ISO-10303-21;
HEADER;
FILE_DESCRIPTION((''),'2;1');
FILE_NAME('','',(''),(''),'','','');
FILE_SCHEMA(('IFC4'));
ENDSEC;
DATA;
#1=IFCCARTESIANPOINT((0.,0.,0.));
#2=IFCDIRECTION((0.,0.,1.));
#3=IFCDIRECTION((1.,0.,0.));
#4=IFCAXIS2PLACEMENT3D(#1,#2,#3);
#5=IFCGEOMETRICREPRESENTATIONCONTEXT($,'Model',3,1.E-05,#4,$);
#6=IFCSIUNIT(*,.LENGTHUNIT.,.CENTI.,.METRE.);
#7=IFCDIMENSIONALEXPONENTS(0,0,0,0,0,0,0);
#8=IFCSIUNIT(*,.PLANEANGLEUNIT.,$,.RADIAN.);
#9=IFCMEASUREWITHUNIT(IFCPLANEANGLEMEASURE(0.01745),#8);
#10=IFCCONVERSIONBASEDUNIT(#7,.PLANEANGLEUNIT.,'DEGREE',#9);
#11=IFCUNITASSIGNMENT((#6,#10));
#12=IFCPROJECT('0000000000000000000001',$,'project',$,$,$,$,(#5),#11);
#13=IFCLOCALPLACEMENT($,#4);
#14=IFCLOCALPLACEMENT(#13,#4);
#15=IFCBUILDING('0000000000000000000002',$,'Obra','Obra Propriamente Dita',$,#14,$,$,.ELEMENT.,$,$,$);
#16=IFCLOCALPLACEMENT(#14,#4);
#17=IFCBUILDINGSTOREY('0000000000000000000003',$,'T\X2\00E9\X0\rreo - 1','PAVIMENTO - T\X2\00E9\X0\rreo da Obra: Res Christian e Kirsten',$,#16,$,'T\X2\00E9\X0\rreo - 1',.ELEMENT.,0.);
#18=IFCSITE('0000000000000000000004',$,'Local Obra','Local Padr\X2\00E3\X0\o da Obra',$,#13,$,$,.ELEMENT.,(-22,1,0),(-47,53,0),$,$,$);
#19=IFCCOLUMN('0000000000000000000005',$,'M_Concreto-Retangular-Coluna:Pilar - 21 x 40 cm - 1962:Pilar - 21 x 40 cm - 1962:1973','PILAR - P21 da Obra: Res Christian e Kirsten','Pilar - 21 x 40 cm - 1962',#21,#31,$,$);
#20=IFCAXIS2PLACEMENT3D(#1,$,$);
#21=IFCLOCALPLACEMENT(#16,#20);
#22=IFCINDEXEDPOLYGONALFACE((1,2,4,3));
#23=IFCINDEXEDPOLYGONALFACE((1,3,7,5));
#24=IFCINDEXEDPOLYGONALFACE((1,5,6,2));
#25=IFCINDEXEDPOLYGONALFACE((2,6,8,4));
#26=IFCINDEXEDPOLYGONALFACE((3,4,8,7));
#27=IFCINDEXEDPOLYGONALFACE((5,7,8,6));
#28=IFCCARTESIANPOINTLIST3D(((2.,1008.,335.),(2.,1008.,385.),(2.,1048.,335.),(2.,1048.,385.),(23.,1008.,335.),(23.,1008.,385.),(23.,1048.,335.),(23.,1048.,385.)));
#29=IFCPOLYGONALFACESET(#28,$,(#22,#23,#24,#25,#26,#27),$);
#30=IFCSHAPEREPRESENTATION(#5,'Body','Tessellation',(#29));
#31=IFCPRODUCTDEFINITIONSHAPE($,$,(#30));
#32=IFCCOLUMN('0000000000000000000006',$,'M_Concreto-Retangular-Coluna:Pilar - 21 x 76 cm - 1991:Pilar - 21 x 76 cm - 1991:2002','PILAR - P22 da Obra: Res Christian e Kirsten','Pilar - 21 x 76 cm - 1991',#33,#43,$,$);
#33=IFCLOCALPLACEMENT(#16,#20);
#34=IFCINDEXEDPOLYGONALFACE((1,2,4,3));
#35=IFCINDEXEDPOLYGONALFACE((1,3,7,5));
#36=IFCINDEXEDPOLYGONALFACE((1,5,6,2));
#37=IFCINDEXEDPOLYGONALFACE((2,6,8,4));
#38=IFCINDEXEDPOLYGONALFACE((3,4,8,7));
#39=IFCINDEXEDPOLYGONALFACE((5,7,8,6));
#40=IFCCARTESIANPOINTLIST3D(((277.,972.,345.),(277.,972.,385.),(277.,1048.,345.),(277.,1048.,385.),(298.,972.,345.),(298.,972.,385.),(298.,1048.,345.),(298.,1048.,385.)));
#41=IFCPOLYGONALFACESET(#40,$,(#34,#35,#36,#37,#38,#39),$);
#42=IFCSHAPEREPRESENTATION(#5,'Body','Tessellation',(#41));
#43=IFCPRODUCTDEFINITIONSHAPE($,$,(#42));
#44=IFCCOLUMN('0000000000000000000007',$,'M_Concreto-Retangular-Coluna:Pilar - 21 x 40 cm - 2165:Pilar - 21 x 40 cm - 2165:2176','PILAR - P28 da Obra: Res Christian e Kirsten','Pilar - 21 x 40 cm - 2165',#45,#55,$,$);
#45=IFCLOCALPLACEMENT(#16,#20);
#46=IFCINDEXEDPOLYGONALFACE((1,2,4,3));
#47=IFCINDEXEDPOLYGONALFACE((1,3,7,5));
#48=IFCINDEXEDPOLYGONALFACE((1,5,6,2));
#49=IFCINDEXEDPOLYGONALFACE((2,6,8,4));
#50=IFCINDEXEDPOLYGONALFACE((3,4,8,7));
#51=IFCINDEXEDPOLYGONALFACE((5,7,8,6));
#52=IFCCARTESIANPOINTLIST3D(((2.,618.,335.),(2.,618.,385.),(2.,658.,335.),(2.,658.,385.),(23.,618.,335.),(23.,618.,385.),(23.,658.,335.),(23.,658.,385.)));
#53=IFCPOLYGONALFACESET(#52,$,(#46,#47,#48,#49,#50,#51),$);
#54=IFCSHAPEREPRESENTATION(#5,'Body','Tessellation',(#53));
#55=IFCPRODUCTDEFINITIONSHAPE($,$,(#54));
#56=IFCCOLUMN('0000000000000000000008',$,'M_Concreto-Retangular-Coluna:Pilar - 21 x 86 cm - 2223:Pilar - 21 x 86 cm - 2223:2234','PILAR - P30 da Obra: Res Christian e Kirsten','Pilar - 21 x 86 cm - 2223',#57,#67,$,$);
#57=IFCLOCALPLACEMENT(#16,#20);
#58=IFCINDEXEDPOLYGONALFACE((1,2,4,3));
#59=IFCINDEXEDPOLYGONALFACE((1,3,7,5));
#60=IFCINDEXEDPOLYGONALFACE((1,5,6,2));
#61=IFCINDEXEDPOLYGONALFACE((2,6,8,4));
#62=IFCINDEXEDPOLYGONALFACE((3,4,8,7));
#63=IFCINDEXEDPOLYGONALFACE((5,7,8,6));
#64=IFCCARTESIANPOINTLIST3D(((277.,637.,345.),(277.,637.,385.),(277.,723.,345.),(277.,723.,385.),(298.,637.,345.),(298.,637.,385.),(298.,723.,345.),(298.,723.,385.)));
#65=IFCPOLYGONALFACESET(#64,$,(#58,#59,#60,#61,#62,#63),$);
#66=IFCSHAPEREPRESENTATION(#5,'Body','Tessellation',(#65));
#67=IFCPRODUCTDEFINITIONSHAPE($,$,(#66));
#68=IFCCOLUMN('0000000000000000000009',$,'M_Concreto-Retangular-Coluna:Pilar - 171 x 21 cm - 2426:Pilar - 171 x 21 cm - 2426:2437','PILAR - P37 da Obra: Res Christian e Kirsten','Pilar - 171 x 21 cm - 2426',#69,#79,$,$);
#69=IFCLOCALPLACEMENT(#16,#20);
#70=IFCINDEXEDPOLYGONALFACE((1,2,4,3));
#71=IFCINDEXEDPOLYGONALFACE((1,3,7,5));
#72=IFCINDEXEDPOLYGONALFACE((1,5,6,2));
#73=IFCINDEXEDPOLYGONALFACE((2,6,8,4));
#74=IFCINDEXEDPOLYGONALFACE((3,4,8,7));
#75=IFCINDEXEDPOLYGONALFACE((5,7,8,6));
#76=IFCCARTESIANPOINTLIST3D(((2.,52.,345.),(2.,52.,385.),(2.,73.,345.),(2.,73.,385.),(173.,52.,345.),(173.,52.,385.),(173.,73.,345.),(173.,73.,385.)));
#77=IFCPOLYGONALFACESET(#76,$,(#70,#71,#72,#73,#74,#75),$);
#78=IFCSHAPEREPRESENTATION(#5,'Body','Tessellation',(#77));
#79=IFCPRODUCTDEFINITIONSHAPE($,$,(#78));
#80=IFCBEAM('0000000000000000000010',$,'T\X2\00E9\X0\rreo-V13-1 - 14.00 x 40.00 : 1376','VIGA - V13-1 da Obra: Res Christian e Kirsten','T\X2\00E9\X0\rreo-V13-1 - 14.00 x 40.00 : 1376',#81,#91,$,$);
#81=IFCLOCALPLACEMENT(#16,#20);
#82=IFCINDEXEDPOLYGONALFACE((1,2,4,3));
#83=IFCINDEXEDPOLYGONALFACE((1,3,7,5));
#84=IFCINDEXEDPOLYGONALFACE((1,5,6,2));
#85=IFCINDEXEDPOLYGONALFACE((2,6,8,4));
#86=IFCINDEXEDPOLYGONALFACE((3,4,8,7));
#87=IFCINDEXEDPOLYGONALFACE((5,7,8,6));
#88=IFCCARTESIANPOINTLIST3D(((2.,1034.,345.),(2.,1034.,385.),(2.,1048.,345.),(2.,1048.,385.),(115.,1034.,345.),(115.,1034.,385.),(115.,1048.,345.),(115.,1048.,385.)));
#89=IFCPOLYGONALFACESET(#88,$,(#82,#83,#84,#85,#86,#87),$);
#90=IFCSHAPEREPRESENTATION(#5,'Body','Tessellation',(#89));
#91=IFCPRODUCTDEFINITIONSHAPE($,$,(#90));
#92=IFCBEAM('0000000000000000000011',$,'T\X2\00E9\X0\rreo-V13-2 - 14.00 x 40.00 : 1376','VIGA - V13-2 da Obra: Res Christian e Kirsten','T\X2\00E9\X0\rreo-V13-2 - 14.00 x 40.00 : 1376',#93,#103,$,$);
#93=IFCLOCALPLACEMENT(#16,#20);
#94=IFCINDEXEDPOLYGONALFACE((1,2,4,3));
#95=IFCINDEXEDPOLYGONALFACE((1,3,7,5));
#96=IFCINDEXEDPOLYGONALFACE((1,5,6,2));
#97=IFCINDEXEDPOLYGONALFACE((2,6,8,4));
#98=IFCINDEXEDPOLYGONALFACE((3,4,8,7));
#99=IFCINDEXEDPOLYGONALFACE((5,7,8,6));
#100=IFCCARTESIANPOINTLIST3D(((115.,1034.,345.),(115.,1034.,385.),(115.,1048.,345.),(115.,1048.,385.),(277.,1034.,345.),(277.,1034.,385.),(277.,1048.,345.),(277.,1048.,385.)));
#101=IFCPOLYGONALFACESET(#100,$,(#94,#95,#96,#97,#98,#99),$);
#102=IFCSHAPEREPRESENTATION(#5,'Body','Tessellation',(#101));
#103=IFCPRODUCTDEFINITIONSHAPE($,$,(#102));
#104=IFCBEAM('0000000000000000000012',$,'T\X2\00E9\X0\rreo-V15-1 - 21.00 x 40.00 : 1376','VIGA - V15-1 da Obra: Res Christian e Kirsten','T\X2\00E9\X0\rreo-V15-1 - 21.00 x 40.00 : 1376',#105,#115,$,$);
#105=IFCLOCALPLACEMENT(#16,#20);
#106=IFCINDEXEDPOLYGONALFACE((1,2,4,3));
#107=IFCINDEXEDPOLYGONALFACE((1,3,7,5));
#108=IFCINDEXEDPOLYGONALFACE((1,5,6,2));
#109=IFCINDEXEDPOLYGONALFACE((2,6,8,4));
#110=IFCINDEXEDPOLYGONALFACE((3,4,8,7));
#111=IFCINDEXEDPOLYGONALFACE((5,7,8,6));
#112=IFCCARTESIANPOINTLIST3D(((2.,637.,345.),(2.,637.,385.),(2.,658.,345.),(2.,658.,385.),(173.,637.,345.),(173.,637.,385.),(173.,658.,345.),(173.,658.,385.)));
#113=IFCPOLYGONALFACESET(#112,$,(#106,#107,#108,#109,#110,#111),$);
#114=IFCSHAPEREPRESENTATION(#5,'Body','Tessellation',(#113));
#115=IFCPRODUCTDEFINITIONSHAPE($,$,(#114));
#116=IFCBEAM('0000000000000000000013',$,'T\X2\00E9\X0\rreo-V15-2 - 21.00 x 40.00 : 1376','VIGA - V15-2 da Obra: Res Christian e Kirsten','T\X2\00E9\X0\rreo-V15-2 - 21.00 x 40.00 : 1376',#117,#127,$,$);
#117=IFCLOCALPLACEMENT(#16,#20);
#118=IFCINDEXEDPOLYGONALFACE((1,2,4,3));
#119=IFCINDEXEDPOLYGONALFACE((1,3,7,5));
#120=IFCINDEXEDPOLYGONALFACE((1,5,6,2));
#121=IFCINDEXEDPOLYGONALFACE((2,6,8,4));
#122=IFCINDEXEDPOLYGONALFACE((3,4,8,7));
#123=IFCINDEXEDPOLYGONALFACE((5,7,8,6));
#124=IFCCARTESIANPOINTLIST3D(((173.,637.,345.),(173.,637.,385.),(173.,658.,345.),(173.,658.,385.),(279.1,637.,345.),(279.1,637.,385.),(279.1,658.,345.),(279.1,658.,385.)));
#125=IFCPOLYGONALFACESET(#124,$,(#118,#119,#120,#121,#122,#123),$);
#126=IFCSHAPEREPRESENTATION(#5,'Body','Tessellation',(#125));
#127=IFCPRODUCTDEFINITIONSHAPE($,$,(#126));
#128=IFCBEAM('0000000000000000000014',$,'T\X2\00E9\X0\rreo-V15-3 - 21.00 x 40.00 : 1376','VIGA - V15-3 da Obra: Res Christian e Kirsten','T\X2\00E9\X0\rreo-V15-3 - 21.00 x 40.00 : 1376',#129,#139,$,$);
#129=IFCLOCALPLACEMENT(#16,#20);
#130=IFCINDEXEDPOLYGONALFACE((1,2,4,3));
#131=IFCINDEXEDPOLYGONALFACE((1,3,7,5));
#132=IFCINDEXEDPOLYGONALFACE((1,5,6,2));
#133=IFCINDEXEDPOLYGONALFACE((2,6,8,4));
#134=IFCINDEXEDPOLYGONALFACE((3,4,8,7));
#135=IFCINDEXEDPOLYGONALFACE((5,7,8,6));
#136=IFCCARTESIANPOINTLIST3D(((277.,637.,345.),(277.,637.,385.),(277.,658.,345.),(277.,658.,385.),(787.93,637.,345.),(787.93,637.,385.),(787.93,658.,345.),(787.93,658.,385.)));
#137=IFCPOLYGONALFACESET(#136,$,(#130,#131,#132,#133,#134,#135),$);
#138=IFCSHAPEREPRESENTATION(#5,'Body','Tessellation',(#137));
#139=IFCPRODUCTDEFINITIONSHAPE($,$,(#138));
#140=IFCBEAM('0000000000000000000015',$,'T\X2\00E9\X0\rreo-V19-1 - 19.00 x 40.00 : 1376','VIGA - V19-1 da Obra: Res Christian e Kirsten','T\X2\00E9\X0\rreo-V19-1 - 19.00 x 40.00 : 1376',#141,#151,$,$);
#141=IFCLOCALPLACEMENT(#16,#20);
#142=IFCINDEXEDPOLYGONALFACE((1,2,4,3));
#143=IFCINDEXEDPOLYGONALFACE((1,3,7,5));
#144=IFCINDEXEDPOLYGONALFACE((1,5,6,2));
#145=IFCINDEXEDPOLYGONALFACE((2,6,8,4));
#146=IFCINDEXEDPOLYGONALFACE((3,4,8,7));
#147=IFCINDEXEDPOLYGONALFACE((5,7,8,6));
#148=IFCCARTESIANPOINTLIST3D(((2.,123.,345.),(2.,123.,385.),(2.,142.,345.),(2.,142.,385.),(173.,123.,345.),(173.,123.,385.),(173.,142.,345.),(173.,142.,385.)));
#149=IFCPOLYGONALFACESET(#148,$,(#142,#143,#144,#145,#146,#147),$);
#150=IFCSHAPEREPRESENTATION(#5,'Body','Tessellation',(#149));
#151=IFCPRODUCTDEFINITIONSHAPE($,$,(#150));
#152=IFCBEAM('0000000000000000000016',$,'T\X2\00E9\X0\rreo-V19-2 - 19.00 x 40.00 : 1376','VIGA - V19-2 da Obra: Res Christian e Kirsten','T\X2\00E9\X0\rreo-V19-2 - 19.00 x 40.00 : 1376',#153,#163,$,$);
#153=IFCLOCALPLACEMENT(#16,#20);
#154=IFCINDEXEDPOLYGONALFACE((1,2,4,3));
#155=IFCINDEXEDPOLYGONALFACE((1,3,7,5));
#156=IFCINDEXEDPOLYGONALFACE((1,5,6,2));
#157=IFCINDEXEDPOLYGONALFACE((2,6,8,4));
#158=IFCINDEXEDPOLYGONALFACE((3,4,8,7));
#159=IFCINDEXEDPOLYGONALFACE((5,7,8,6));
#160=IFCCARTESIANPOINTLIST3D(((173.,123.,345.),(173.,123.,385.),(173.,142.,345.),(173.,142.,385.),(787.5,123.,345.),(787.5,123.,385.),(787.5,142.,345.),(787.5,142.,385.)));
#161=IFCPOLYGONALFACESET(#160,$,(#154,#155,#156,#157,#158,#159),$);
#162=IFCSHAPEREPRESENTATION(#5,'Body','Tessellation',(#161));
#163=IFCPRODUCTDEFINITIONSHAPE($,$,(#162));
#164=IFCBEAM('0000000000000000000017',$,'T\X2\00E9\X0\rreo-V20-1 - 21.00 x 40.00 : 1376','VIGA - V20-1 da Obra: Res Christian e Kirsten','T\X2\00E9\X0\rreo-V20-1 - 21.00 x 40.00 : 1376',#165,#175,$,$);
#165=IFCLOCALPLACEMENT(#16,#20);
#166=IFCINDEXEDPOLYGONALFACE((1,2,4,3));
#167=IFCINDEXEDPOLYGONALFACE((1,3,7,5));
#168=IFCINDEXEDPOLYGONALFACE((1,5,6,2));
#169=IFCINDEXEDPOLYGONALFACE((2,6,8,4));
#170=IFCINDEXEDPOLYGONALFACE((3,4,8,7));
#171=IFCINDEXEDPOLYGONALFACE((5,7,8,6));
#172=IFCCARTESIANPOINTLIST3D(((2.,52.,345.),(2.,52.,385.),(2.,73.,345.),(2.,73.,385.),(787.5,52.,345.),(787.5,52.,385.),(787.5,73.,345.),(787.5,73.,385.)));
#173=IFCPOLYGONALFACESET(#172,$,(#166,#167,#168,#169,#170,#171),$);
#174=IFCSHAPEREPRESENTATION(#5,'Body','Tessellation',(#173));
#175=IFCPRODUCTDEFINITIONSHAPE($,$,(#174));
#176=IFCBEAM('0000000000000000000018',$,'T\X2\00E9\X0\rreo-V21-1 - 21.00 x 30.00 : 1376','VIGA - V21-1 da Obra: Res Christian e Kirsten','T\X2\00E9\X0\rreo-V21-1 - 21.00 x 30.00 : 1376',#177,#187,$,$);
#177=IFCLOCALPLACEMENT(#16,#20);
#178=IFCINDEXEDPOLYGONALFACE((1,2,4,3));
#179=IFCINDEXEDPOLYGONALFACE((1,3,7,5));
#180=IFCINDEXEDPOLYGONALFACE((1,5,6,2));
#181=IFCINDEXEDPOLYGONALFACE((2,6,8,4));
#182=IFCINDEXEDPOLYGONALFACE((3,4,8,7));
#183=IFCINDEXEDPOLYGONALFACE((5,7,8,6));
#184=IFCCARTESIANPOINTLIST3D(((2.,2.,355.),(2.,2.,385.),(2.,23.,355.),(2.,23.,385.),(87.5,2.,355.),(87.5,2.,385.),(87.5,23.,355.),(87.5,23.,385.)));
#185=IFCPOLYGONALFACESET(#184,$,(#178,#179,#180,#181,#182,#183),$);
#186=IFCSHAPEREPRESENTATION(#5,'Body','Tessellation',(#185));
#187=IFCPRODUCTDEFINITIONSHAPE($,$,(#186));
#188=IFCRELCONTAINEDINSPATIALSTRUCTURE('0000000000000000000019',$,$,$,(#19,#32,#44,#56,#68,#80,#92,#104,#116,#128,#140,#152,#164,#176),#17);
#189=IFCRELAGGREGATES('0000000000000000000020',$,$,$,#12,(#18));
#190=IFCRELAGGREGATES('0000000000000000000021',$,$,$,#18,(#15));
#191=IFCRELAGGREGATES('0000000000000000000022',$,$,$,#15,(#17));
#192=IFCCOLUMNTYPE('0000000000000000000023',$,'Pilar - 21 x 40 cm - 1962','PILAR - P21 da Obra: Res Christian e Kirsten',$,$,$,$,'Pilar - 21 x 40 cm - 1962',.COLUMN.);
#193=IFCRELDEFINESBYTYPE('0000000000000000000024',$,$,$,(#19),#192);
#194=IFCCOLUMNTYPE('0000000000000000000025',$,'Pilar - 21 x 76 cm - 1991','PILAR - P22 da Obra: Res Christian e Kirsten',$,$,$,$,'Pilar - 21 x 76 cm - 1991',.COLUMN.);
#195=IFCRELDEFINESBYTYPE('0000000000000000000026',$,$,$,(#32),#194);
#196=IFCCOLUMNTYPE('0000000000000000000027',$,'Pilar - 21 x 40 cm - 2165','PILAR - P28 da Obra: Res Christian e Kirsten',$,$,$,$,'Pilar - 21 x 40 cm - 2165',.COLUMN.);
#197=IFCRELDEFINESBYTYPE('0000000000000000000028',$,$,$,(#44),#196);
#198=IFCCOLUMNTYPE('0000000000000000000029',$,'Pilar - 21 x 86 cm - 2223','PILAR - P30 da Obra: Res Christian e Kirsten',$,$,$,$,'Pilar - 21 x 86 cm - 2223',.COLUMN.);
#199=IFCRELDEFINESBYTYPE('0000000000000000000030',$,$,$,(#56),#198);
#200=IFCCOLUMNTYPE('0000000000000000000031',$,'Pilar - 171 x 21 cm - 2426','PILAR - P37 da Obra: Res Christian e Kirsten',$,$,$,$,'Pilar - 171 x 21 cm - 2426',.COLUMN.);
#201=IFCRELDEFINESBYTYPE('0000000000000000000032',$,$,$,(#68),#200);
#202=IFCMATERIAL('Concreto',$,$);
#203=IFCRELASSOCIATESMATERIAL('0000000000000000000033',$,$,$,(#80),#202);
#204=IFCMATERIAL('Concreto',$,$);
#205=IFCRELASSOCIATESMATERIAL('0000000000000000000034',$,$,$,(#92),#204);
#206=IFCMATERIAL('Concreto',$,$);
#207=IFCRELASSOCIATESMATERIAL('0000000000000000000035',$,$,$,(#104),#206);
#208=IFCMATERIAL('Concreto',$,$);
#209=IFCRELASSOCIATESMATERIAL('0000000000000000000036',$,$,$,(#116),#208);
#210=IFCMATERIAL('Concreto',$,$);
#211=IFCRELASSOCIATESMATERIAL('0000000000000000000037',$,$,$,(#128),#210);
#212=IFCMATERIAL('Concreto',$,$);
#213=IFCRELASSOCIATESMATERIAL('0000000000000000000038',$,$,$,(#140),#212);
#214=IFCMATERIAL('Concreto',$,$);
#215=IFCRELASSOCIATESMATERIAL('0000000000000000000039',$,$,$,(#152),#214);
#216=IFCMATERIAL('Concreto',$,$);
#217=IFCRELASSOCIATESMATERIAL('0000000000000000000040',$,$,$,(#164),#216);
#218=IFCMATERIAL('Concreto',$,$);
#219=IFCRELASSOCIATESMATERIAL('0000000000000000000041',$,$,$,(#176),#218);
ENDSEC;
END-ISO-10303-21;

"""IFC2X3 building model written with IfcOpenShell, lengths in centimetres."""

from ifc_helpers import new_model, entity, si_unit, converted_unit, frame, origin, origin_with_axes, origin_2d_with_axis, place, context, project, spatial, polyline, rectangle, outline, extrude, source, transform, mapped, material, type_object, type_shapes, element, save


model = new_model("IFC2X3")

# Units and contexts
model_context = context("Model", 3, precision=1e-05, world=origin_with_axes())
ifc_project = project(units=[si_unit("LENGTHUNIT", "METRE", prefix="CENTI"), converted_unit("PLANEANGLEUNIT", "DEGREE", entity("IfcPlaneAngleMeasure", 0.01745), si_unit("PLANEANGLEUNIT", "RADIAN"), dimensions=[0, 0, 0, 0, 0, 0, 0])], contexts=[model_context])

# Site, building, storey
site_placement = place(None, origin_with_axes())
site = spatial("IfcSite", under=ifc_project, at=site_placement, Name="Local Obra", Description="Local Padrão da Obra", CompositionType="ELEMENT", RefLatitude=(-22, 1, 0), RefLongitude=(-47, 53, 0))
building_placement = place(site_placement, origin_with_axes())
building = spatial("IfcBuilding", under=site, at=building_placement, Name="Obra", Description="Obra Propriamente Dita", CompositionType="ELEMENT")
storey_placement = place(building_placement, origin_with_axes())
storey = spatial("IfcBuildingStorey", under=building, at=storey_placement, Name="Térreo - 1", Description="PAVIMENTO - Térreo da Obra: Res Christian e Kirsten", LongName="Térreo - 1", CompositionType="ELEMENT", Elevation=0.0)

# Columns
column_type_1 = type_object("IfcColumnType", Name="Pilar - 21 x 40 cm - 1962", Description="PILAR - P21 da Obra: Res Christian e Kirsten", ElementType="Pilar - 21 x 40 cm - 1962", PredefinedType="COLUMN")
shared_shape_1 = source(origin(), model_context, "Body", "SweptSolid", [
    extrude(rectangle(XDim=21.0, YDim=40.0, at=origin_2d_with_axis()), origin(), (0.0, 0.0, 1.0), 50.0),
])
type_shapes(column_type_1, [shared_shape_1])
column_1_placement = place(storey_placement, frame((12.5, 1028.0, 335.0), z_axis=(0.0, 0.0, 1.0), x_axis=(1.0, 0.0, 0.0)))
element("IfcColumn", 1, at=column_1_placement, inside=storey, type_object=column_type_1, Name="M_Concreto-Retangular-Coluna:Pilar - 21 x 40 cm - 1962:Pilar - 21 x 40 cm - 1962:1973", Description="PILAR - P21 da Obra: Res Christian e Kirsten", ObjectType="Pilar - 21 x 40 cm - 1962", context=model_context, shape_type="MappedRepresentation", body=[
    mapped(shared_shape_1, transform((0.0, 0.0, 0.0), scale=1.0)),
])
column_type_2 = type_object("IfcColumnType", Name="Pilar - 21 x 76 cm - 1991", Description="PILAR - P22 da Obra: Res Christian e Kirsten", ElementType="Pilar - 21 x 76 cm - 1991", PredefinedType="COLUMN")
shared_shape_2 = source(origin(), model_context, "Body", "SweptSolid", [
    extrude(rectangle(XDim=21.0, YDim=76.0, at=origin_2d_with_axis()), origin(), (0.0, 0.0, 1.0), 40.0),
])
type_shapes(column_type_2, [shared_shape_2])
column_2_placement = place(storey_placement, frame((287.5, 1010.0, 345.0), z_axis=(0.0, 0.0, 1.0), x_axis=(1.0, 0.0, 0.0)))
element("IfcColumn", 2, at=column_2_placement, inside=storey, type_object=column_type_2, Name="M_Concreto-Retangular-Coluna:Pilar - 21 x 76 cm - 1991:Pilar - 21 x 76 cm - 1991:2002", Description="PILAR - P22 da Obra: Res Christian e Kirsten", ObjectType="Pilar - 21 x 76 cm - 1991", context=model_context, shape_type="MappedRepresentation", body=[
    mapped(shared_shape_2, transform((0.0, 0.0, 0.0), scale=1.0)),
])
column_type_3 = type_object("IfcColumnType", Name="Pilar - 21 x 40 cm - 2165", Description="PILAR - P28 da Obra: Res Christian e Kirsten", ElementType="Pilar - 21 x 40 cm - 2165", PredefinedType="COLUMN")
shared_shape_3 = source(origin(), model_context, "Body", "SweptSolid", [
    extrude(rectangle(XDim=21.0, YDim=40.0, at=origin_2d_with_axis()), origin(), (0.0, 0.0, 1.0), 50.0),
])
type_shapes(column_type_3, [shared_shape_3])
column_3_placement = place(storey_placement, frame((12.5, 638.0, 335.0), z_axis=(0.0, 0.0, 1.0), x_axis=(1.0, 0.0, 0.0)))
element("IfcColumn", 3, at=column_3_placement, inside=storey, type_object=column_type_3, Name="M_Concreto-Retangular-Coluna:Pilar - 21 x 40 cm - 2165:Pilar - 21 x 40 cm - 2165:2176", Description="PILAR - P28 da Obra: Res Christian e Kirsten", ObjectType="Pilar - 21 x 40 cm - 2165", context=model_context, shape_type="MappedRepresentation", body=[
    mapped(shared_shape_3, transform((0.0, 0.0, 0.0), scale=1.0)),
])
column_type_4 = type_object("IfcColumnType", Name="Pilar - 21 x 86 cm - 2223", Description="PILAR - P30 da Obra: Res Christian e Kirsten", ElementType="Pilar - 21 x 86 cm - 2223", PredefinedType="COLUMN")
shared_shape_4 = source(origin(), model_context, "Body", "SweptSolid", [
    extrude(rectangle(XDim=21.0, YDim=86.0, at=origin_2d_with_axis()), origin(), (0.0, 0.0, 1.0), 40.0),
])
type_shapes(column_type_4, [shared_shape_4])
column_4_placement = place(storey_placement, frame((287.5, 680.0, 345.0), z_axis=(0.0, 0.0, 1.0), x_axis=(1.0, 0.0, 0.0)))
element("IfcColumn", 4, at=column_4_placement, inside=storey, type_object=column_type_4, Name="M_Concreto-Retangular-Coluna:Pilar - 21 x 86 cm - 2223:Pilar - 21 x 86 cm - 2223:2234", Description="PILAR - P30 da Obra: Res Christian e Kirsten", ObjectType="Pilar - 21 x 86 cm - 2223", context=model_context, shape_type="MappedRepresentation", body=[
    mapped(shared_shape_4, transform((0.0, 0.0, 0.0), scale=1.0)),
])
column_type_5 = type_object("IfcColumnType", Name="Pilar - 171 x 21 cm - 2426", Description="PILAR - P37 da Obra: Res Christian e Kirsten", ElementType="Pilar - 171 x 21 cm - 2426", PredefinedType="COLUMN")
shared_shape_5 = source(origin(), model_context, "Body", "SweptSolid", [
    extrude(rectangle(XDim=171.0, YDim=21.0, at=origin_2d_with_axis()), origin(), (0.0, 0.0, 1.0), 40.0),
])
type_shapes(column_type_5, [shared_shape_5])
column_5_placement = place(storey_placement, frame((87.5, 62.5, 345.0), z_axis=(0.0, 0.0, 1.0), x_axis=(1.0, 0.0, 0.0)))
element("IfcColumn", 5, at=column_5_placement, inside=storey, type_object=column_type_5, Name="M_Concreto-Retangular-Coluna:Pilar - 171 x 21 cm - 2426:Pilar - 171 x 21 cm - 2426:2437", Description="PILAR - P37 da Obra: Res Christian e Kirsten", ObjectType="Pilar - 171 x 21 cm - 2426", context=model_context, shape_type="MappedRepresentation", body=[
    mapped(shared_shape_5, transform((0.0, 0.0, 0.0), scale=1.0)),
])

# Beams
ifc_material_1 = material(Name="Concreto")
beam_1_placement = place(storey_placement, frame((2.0, 1048.0, 385.0), z_axis=(1.0, 0.0, 0.0), x_axis=(0.0, -1.0, 0.0)))
element("IfcBeam", 6, at=beam_1_placement, inside=storey, material=ifc_material_1, Name="Térreo-V13-1 - 14.00 x 40.00 : 1376", Description="VIGA - V13-1 da Obra: Res Christian e Kirsten", ObjectType="Térreo-V13-1 - 14.00 x 40.00 : 1376", context=model_context, shape_type="SweptSolid", body=[
    extrude(outline(polyline([(0.0, 0.0), (14.0, 0.0), (14.0, 40.0), (0.0, 40.0), (0.0, 0.0)])), origin_with_axes(), (0.0, 0.0, 1.0), 113.0),
])
ifc_material_2 = material(Name="Concreto")
beam_2_placement = place(storey_placement, frame((115.0, 1048.0, 385.0), z_axis=(1.0, 0.0, 0.0), x_axis=(0.0, -1.0, 0.0)))
element("IfcBeam", 7, at=beam_2_placement, inside=storey, material=ifc_material_2, Name="Térreo-V13-2 - 14.00 x 40.00 : 1376", Description="VIGA - V13-2 da Obra: Res Christian e Kirsten", ObjectType="Térreo-V13-2 - 14.00 x 40.00 : 1376", context=model_context, shape_type="SweptSolid", body=[
    extrude(outline(polyline([(0.0, 0.0), (14.0, 0.0), (14.0, 40.0), (0.0, 40.0), (0.0, 0.0)])), origin_with_axes(), (0.0, 0.0, 1.0), 162.0),
])
ifc_material_3 = material(Name="Concreto")
beam_3_placement = place(storey_placement, frame((2.0, 658.0, 385.0), z_axis=(1.0, -0.000001, 0.0), x_axis=(-0.000001, -1.0, 0.0)))
element("IfcBeam", 8, at=beam_3_placement, inside=storey, material=ifc_material_3, Name="Térreo-V15-1 - 21.00 x 40.00 : 1376", Description="VIGA - V15-1 da Obra: Res Christian e Kirsten", ObjectType="Térreo-V15-1 - 21.00 x 40.00 : 1376", context=model_context, shape_type="SweptSolid", body=[
    extrude(outline(polyline([(0.0, 0.0), (21.0, 0.0), (21.0, 40.0), (0.0, 40.0), (0.0, 0.0)])), origin_with_axes(), (0.0, 0.0, 1.0), 171.0),
])
ifc_material_4 = material(Name="Concreto")
beam_4_placement = place(storey_placement, frame((173.0, 658.0, 385.0), z_axis=(1.0, 0.000002, 0.0), x_axis=(0.000002, -1.0, 0.0)))
element("IfcBeam", 9, at=beam_4_placement, inside=storey, material=ifc_material_4, Name="Térreo-V15-2 - 21.00 x 40.00 : 1376", Description="VIGA - V15-2 da Obra: Res Christian e Kirsten", ObjectType="Térreo-V15-2 - 21.00 x 40.00 : 1376", context=model_context, shape_type="SweptSolid", body=[
    extrude(outline(polyline([(0.0, 0.0), (21.0, 0.0), (21.0, 40.0), (0.0, 40.0), (0.0, 0.0)])), origin_with_axes(), (0.0, 0.0, 1.0), 106.1),
])
ifc_material_5 = material(Name="Concreto")
beam_5_placement = place(storey_placement, frame((277.0, 637.0, 385.0), z_axis=(1.0, 0.0, 0.0), x_axis=(0.0, -1.0, 0.0)))
element("IfcBeam", 10, at=beam_5_placement, inside=storey, material=ifc_material_5, Name="Térreo-V15-3 - 21.00 x 40.00 : 1376", Description="VIGA - V15-3 da Obra: Res Christian e Kirsten", ObjectType="Térreo-V15-3 - 21.00 x 40.00 : 1376", context=model_context, shape_type="SweptSolid", body=[
    extrude(outline(polyline([(-21.0, 0.0), (0.0, 0.0), (0.0, 40.0), (-21.0, 40.0), (-21.0, 0.0)])), origin_with_axes(), (0.0, 0.0, 1.0), 510.93),
])
ifc_material_6 = material(Name="Concreto")
beam_6_placement = place(storey_placement, frame((2.0, 142.0, 385.0), z_axis=(1.0, 0.0, 0.0), x_axis=(0.0, -1.0, 0.0)))
element("IfcBeam", 11, at=beam_6_placement, inside=storey, material=ifc_material_6, Name="Térreo-V19-1 - 19.00 x 40.00 : 1376", Description="VIGA - V19-1 da Obra: Res Christian e Kirsten", ObjectType="Térreo-V19-1 - 19.00 x 40.00 : 1376", context=model_context, shape_type="SweptSolid", body=[
    extrude(outline(polyline([(0.0, 0.0), (19.0, 0.0), (19.0, 40.0), (0.0, 40.0), (0.0, 0.0)])), origin_with_axes(), (0.0, 0.0, 1.0), 171.0),
])
ifc_material_7 = material(Name="Concreto")
beam_7_placement = place(storey_placement, frame((173.0, 142.0, 385.0), z_axis=(1.0, 0.0, 0.0), x_axis=(0.0, -1.0, 0.0)))
element("IfcBeam", 12, at=beam_7_placement, inside=storey, material=ifc_material_7, Name="Térreo-V19-2 - 19.00 x 40.00 : 1376", Description="VIGA - V19-2 da Obra: Res Christian e Kirsten", ObjectType="Térreo-V19-2 - 19.00 x 40.00 : 1376", context=model_context, shape_type="SweptSolid", body=[
    extrude(outline(polyline([(0.0, 0.0), (19.0, 0.0), (19.0, 40.0), (0.0, 40.0), (0.0, 0.0)])), origin_with_axes(), (0.0, 0.0, 1.0), 614.5),
])
ifc_material_8 = material(Name="Concreto")
beam_8_placement = place(storey_placement, frame((2.0, 52.0, 385.0), z_axis=(1.0, 0.0, 0.0), x_axis=(0.0, -1.0, 0.0)))
element("IfcBeam", 13, at=beam_8_placement, inside=storey, material=ifc_material_8, Name="Térreo-V20-1 - 21.00 x 40.00 : 1376", Description="VIGA - V20-1 da Obra: Res Christian e Kirsten", ObjectType="Térreo-V20-1 - 21.00 x 40.00 : 1376", context=model_context, shape_type="SweptSolid", body=[
    extrude(outline(polyline([(-21.0, 0.0), (0.0, 0.0), (0.0, 40.0), (-21.0, 40.0), (-21.0, 0.0)])), origin_with_axes(), (0.0, 0.0, 1.0), 785.5),
])
ifc_material_9 = material(Name="Concreto")
beam_9_placement = place(storey_placement, frame((2.0, 2.0, 385.0), z_axis=(1.0, 0.0, 0.0), x_axis=(0.0, -1.0, 0.0)))
element("IfcBeam", 14, at=beam_9_placement, inside=storey, material=ifc_material_9, Name="Térreo-V21-1 - 21.00 x 30.00 : 1376", Description="VIGA - V21-1 da Obra: Res Christian e Kirsten", ObjectType="Térreo-V21-1 - 21.00 x 30.00 : 1376", context=model_context, shape_type="SweptSolid", body=[
    extrude(outline(polyline([(-21.0, 0.0), (0.0, 0.0), (0.0, 30.0), (-21.0, 30.0), (-21.0, 0.0)])), origin_with_axes(), (0.0, 0.0, 1.0), 85.5),
])

save(model, "model.ifc")
